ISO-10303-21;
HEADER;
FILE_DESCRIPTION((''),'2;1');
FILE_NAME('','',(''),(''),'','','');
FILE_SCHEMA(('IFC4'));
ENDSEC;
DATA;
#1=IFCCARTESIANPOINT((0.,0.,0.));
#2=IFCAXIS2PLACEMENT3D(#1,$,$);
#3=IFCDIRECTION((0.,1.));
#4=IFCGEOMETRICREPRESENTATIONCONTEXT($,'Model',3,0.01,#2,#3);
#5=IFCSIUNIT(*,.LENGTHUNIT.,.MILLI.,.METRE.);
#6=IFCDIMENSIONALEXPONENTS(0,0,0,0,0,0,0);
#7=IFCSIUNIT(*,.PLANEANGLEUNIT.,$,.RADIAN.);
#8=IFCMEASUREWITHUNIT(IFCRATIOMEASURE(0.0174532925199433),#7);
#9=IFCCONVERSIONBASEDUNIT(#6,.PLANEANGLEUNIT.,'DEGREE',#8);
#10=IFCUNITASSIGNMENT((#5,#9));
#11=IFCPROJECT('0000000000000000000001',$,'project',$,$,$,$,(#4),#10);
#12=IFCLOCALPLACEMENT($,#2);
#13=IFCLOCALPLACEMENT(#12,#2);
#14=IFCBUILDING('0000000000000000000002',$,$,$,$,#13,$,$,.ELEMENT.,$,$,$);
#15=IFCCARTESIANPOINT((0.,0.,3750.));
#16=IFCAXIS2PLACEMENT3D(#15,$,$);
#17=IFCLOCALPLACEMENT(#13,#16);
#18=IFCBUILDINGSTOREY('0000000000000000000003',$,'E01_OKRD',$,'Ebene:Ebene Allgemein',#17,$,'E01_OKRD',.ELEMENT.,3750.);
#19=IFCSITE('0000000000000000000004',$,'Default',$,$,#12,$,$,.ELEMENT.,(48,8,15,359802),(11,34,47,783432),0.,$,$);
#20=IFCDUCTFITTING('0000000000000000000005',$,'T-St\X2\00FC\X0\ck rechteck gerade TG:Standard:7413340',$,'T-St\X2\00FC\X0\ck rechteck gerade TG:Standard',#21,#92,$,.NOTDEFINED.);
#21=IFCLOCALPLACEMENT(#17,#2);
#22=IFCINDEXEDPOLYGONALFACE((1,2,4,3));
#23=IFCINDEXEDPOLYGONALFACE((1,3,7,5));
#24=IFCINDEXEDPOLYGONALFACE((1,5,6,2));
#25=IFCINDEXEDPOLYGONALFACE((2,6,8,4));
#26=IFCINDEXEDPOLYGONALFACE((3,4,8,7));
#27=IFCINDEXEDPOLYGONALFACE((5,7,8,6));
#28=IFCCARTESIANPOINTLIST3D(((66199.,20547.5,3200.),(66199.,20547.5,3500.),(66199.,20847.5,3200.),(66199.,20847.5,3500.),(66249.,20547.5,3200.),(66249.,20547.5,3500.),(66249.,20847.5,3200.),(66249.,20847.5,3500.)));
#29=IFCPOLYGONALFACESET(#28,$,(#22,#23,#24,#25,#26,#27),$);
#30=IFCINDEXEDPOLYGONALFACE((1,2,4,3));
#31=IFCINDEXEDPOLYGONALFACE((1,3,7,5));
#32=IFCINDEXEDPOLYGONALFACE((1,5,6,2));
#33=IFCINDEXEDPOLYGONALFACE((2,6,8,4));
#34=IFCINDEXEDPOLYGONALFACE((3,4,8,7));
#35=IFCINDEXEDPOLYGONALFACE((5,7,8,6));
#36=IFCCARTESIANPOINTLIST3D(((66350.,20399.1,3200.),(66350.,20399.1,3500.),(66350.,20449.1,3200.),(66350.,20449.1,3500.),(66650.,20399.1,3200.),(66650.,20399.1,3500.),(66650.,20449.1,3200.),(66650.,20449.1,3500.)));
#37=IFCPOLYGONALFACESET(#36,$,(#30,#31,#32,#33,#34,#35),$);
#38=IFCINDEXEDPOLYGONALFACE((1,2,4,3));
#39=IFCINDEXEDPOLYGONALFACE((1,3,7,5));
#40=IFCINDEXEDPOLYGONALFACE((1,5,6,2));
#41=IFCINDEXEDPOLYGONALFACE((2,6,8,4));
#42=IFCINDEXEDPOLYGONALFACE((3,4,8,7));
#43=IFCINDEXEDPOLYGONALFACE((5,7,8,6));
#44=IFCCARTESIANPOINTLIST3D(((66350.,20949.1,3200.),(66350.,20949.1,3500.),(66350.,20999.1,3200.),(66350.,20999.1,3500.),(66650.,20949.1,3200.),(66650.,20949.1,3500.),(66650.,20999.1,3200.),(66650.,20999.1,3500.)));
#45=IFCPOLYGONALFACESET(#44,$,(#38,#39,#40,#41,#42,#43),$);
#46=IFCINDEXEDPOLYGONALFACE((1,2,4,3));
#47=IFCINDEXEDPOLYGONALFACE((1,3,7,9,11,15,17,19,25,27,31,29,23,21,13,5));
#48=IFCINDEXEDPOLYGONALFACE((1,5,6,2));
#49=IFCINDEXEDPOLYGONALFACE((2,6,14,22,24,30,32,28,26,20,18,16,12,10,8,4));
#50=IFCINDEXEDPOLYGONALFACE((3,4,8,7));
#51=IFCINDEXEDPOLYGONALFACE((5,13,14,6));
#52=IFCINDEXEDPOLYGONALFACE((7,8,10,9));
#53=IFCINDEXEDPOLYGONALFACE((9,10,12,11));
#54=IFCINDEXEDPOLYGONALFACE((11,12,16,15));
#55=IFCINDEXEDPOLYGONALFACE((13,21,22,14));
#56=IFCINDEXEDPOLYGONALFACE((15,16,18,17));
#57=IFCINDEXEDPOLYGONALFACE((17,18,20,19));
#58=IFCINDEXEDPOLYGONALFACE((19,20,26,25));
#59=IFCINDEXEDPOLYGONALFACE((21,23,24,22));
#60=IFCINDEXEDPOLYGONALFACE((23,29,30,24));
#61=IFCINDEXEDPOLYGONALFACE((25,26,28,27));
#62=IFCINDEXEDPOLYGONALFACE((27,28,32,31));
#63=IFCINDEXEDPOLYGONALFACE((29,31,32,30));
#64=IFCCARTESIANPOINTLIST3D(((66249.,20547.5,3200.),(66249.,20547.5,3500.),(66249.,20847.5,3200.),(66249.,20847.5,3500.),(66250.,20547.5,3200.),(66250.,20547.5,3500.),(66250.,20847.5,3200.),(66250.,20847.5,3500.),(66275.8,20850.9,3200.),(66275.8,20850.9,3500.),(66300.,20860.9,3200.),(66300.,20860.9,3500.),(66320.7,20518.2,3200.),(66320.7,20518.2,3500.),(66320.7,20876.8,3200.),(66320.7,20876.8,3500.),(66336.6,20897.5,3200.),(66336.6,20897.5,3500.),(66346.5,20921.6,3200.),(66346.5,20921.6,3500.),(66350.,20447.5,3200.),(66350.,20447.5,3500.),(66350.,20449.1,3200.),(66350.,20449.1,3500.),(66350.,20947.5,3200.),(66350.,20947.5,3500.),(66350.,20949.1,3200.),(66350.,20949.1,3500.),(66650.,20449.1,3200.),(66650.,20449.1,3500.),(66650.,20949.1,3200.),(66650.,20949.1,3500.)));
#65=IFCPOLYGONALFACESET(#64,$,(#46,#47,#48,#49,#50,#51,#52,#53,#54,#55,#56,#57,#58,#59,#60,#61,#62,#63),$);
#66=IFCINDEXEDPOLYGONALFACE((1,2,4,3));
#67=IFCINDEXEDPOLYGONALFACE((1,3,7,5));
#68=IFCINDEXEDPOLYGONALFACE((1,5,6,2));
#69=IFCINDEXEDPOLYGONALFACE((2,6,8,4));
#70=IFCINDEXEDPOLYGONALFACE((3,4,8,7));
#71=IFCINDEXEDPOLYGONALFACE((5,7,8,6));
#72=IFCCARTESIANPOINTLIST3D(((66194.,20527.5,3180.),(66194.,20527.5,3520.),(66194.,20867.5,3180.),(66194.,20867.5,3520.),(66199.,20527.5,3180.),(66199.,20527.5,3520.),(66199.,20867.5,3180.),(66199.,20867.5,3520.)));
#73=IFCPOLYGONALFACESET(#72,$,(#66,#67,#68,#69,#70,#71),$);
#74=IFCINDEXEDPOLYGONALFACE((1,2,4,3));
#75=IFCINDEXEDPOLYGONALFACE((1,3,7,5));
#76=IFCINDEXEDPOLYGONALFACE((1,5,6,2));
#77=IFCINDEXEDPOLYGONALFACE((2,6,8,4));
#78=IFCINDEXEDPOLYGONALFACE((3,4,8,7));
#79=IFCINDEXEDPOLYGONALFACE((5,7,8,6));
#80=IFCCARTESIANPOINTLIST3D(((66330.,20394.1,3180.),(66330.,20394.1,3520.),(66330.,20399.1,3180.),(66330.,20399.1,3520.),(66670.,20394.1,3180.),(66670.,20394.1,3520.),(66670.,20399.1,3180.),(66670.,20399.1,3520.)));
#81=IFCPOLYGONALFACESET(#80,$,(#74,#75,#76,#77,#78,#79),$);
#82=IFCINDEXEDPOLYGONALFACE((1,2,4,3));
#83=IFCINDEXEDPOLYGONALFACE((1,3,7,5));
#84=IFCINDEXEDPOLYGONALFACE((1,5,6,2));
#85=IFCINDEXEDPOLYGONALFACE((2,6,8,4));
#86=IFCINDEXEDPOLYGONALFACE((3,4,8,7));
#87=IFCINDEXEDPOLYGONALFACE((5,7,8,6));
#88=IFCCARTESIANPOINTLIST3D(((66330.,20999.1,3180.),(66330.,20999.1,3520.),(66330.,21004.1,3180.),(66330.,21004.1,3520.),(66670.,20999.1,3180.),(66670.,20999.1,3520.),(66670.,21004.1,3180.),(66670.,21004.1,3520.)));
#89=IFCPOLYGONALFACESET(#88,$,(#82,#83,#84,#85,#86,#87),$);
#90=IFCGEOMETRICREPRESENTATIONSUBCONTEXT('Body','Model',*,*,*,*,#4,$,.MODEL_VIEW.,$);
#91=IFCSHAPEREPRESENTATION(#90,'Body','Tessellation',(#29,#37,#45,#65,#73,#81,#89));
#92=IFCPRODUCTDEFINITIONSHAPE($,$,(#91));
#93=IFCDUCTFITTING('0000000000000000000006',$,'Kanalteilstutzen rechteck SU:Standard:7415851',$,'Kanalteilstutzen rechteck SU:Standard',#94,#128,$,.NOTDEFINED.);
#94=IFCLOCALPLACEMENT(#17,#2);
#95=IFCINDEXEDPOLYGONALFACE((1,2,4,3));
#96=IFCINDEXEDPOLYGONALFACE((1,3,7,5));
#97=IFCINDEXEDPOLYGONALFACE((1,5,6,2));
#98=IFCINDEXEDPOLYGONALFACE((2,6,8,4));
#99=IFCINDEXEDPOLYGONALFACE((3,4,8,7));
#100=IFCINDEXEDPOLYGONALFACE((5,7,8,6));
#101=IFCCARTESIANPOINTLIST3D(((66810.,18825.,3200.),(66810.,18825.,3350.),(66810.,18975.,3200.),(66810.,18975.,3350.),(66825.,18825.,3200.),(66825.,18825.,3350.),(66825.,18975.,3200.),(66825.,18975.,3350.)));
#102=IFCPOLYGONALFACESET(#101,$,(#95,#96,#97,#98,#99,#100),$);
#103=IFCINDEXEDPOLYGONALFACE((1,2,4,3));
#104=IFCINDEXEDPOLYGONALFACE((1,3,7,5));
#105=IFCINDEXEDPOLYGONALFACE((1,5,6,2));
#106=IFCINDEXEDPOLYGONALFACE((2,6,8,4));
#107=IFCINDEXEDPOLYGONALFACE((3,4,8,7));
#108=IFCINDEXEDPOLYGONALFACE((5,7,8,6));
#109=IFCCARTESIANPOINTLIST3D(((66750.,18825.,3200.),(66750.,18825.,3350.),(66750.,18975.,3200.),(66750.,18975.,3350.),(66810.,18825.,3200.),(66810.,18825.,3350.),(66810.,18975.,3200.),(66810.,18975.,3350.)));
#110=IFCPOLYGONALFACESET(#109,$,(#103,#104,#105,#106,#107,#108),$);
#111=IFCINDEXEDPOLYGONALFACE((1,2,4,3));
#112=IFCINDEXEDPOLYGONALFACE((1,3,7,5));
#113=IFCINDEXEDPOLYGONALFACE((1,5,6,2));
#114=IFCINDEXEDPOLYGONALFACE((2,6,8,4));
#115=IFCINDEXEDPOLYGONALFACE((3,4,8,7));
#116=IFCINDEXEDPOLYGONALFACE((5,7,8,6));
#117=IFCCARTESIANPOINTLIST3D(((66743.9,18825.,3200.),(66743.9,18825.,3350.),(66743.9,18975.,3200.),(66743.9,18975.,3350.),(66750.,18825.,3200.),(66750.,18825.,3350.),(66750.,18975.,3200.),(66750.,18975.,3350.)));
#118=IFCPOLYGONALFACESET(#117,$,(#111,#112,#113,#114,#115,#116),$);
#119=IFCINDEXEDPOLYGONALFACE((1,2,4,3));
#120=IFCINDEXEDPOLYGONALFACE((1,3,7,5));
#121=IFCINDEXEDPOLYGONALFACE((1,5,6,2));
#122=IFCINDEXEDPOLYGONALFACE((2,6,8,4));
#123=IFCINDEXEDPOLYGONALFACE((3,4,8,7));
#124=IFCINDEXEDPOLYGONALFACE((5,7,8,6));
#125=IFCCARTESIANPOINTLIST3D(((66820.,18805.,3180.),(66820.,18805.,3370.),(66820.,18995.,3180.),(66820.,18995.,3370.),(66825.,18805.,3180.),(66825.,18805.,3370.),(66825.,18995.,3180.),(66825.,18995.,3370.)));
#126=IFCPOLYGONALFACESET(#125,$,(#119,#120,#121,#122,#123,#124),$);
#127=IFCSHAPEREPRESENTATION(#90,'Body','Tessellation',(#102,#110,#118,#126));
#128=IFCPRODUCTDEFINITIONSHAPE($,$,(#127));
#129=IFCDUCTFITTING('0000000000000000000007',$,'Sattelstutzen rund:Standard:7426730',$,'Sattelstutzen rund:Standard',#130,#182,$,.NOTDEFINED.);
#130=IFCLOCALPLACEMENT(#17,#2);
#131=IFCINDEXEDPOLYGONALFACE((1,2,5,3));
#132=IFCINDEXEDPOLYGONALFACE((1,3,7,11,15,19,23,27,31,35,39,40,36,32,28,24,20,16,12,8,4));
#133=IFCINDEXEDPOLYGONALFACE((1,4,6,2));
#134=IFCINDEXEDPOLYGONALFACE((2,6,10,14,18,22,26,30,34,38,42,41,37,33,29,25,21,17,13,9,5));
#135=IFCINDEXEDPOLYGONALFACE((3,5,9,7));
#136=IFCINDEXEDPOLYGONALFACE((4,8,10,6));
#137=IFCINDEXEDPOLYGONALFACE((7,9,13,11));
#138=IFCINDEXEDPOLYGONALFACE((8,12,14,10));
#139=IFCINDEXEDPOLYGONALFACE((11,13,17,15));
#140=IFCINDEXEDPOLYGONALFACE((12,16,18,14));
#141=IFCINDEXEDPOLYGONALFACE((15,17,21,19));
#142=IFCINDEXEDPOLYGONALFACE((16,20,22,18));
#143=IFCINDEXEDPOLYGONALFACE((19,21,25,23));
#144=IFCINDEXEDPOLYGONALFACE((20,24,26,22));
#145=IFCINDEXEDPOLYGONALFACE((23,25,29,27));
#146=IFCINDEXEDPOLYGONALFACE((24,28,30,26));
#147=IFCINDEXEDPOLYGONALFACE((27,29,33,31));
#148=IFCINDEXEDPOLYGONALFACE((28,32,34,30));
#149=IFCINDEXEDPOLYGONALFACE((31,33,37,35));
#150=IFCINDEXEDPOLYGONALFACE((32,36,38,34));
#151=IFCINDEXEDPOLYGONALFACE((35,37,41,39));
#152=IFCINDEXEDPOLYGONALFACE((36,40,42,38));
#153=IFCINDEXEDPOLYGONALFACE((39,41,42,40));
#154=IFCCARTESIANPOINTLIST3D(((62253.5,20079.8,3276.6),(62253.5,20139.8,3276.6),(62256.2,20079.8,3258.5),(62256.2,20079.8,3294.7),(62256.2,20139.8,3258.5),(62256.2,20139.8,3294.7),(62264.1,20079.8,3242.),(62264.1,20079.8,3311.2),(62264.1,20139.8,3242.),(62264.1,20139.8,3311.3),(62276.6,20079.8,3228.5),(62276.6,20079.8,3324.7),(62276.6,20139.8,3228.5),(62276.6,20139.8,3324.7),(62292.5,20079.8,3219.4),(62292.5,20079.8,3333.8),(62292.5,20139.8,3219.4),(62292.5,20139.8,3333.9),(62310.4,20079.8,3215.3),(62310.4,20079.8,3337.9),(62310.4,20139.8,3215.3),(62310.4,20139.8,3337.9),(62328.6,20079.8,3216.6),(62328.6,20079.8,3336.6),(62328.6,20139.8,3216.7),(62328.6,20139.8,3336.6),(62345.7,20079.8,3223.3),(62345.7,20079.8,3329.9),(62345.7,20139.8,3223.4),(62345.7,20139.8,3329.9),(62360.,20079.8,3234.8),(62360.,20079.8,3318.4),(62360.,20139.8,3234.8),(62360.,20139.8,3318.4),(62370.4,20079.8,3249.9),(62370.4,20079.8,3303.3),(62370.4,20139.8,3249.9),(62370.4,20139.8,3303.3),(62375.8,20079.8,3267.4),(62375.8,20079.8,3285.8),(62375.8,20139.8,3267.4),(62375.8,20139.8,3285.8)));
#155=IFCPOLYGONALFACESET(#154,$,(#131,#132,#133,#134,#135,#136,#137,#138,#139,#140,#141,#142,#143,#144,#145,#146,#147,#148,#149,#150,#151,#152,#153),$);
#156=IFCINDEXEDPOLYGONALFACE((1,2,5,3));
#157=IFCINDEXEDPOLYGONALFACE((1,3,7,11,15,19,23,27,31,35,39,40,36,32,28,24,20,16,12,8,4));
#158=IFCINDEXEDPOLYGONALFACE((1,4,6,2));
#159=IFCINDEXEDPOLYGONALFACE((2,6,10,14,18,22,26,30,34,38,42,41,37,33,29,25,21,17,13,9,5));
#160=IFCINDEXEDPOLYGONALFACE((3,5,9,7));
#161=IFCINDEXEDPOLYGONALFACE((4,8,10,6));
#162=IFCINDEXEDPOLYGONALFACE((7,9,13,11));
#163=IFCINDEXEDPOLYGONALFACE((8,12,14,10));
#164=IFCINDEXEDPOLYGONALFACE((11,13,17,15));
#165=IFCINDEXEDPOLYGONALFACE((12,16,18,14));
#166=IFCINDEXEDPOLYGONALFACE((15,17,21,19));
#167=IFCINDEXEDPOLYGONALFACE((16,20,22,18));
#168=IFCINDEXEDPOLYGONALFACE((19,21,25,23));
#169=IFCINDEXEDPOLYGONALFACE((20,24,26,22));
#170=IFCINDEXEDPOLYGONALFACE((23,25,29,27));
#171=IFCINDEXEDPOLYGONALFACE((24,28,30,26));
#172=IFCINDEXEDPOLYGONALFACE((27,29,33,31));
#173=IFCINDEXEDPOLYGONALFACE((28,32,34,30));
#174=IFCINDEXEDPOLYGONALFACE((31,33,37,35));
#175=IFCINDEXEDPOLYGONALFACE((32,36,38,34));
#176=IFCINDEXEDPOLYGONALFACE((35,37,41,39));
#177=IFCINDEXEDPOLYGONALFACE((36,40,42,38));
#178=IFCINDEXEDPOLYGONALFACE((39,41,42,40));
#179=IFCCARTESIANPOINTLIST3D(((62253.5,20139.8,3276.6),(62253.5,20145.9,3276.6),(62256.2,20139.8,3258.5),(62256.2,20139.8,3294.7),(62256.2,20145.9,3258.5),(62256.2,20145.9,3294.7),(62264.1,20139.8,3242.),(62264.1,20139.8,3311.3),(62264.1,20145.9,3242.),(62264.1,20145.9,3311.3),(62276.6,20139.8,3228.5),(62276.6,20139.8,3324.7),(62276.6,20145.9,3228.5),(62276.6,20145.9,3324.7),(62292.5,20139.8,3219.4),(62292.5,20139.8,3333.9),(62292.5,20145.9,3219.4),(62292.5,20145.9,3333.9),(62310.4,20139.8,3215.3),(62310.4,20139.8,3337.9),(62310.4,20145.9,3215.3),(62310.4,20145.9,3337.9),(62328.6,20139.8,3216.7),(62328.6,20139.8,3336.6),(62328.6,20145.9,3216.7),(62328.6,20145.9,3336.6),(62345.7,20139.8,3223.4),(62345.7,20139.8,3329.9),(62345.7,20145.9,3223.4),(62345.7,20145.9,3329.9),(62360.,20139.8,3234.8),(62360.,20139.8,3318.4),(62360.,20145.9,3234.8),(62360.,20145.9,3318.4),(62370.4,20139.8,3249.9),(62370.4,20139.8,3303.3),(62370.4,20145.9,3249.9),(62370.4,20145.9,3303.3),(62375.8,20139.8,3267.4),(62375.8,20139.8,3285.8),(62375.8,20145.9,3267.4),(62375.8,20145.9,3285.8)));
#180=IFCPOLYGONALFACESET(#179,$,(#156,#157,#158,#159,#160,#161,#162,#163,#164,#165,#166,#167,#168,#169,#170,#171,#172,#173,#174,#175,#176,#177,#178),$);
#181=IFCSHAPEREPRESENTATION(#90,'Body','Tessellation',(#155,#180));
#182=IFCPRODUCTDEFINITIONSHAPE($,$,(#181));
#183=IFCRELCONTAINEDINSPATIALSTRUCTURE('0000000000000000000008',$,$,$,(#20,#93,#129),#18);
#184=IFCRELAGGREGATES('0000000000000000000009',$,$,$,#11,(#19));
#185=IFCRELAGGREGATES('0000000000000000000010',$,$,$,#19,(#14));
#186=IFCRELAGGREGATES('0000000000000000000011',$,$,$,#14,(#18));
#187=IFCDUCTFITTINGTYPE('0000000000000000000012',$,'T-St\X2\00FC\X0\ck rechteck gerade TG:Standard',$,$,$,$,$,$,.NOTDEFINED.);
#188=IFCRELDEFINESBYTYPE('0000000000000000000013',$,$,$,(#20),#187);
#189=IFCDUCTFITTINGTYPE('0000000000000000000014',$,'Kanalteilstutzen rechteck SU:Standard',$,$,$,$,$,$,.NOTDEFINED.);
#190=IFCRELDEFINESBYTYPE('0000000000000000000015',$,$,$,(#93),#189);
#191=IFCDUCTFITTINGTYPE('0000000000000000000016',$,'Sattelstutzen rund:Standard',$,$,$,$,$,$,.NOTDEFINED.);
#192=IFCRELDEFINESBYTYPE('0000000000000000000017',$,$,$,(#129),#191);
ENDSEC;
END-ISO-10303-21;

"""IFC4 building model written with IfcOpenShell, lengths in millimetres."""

from ifc_helpers import new_model, entity, si_unit, converted_unit, direction, frame, frame_2d, origin, origin_2d_with_axis, place, context, subcontext, project, spatial, polyline, circle_curve, parameter, trimmed, segment, composite_curve, rectangle, circle, outline, extrude, source, transform, mapped, type_object, type_shapes, element, save


model = new_model("IFC4")

# Units and contexts
model_context = context("Model", 3, precision=0.01, world=origin(), true_north=direction((0.0, 1.0)))
body_context = subcontext(model_context, "Body", "Model", "MODEL_VIEW")
ifc_project = project(units=[si_unit("LENGTHUNIT", "METRE", prefix="MILLI"), converted_unit("PLANEANGLEUNIT", "DEGREE", entity("IfcRatioMeasure", 0.0174532925199433), si_unit("PLANEANGLEUNIT", "RADIAN"), dimensions=[0, 0, 0, 0, 0, 0, 0])], contexts=[model_context])

# Site, building, storey
site_placement = place(None, origin())
site = spatial("IfcSite", under=ifc_project, at=site_placement, Name="Default", CompositionType="ELEMENT", RefLatitude=(48, 8, 15, 359802), RefLongitude=(11, 34, 47, 783432), RefElevation=0.0)
building_placement = place(site_placement, origin())
building = spatial("IfcBuilding", under=site, at=building_placement, CompositionType="ELEMENT")
storey_placement = place(building_placement, frame((0.0, 0.0, 3750.0)))
storey = spatial("IfcBuildingStorey", under=building, at=storey_placement, Name="E01_OKRD", ObjectType="Ebene:Ebene Allgemein", LongName="E01_OKRD", CompositionType="ELEMENT", Elevation=3750.0)

# Duct fittings
duct_fitting_type_1 = type_object("IfcDuctFittingType", Name="T-Stück rechteck gerade TG:Standard", PredefinedType="NOTDEFINED")
shared_shape_1 = source(origin(), body_context, "Body", "SweptSolid", [
    extrude(rectangle(XDim=50.0, YDim=300.0, at=frame_2d((0.0, 0.0), x_axis=(1.0, 0.0))), frame((0.0, -276.0, -150.0), z_axis=(0.0, 0.0, 1.0), x_axis=(0.0, -1.0, 0.0)), (0.0, 0.0, 1.0), 300.0),
    extrude(rectangle(XDim=50.0, YDim=300.0, at=frame_2d((0.0, 0.0), x_axis=(1.0, 0.0))), frame((273.4, 0.0, -150.0), z_axis=(0.0, 0.0, 1.0), x_axis=(-1.0, 0.0, 0.0)), (0.0, 0.0, 1.0), 300.0),
    extrude(rectangle(XDim=50.0, YDim=300.0, at=origin_2d_with_axis()), frame((-276.6, 0.0, -150.0)), (0.0, 0.0, 1.0), 300.0),
    extrude(outline(composite_curve([segment(trimmed(circle_curve(frame_2d((-250.6, -119.8), x_axis=(-1.0, 0.0)), 100.0), [parameter(180.0)], [parameter(270.0)], True, "PARAMETER"), False, "CONTINUOUS"), segment(polyline([(-150.6, -119.8), (-150.6, -120.8)]), True, "CONTINUOUS"), segment(polyline([(-150.6, -120.8), (149.4, -120.8)]), True, "CONTINUOUS"), segment(polyline([(149.4, -120.8), (149.4, -119.8)]), True, "CONTINUOUS"), segment(trimmed(circle_curve(frame_2d((249.4, -119.8), x_axis=(-1.0, 0.0)), 100.0), [parameter(270.0)], [parameter(0.0)], True, "PARAMETER"), False, "CONTINUOUS"), segment(polyline([(249.4, -19.8), (251.0, -19.8)]), True, "CONTINUOUS"), segment(polyline([(251.0, -19.8), (251.0, 280.2)]), True, "CONTINUOUS"), segment(polyline([(251.0, 280.2), (-249.0, 280.2)]), True, "CONTINUOUS"), segment(polyline([(-249.0, 280.2), (-249.0, -19.8)]), True, "CONTINUOUS"), segment(polyline([(-249.0, -19.8), (-250.6, -19.8)]), True, "CONTINUOUS")], self_intersect=False)), frame((-0.6, -130.2, -150.0), z_axis=(0.0, 0.0, -1.0), x_axis=(-1.0, 0.0, 0.0)), (0.0, 0.0, -1.0), 300.0),
    extrude(rectangle(XDim=5.0, YDim=340.0, at=frame_2d((0.0, 0.0), x_axis=(1.0, 0.0))), frame((0.0, -303.5, -170.0), z_axis=(0.0, 0.0, 1.0), x_axis=(0.0, 1.0, 0.0)), (0.0, 0.0, 1.0), 340.0),
    extrude(rectangle(XDim=5.0, YDim=340.0, at=frame_2d((0.0, 0.0), x_axis=(1.0, 0.0))), frame((300.9, 0.0, -170.0), z_axis=(0.0, 0.0, 1.0), x_axis=(-1.0, 0.0, 0.0)), (0.0, 0.0, 1.0), 340.0),
    extrude(rectangle(XDim=5.0, YDim=340.0, at=origin_2d_with_axis()), frame((-304.1, 0.0, -170.0), z_axis=(0.0, 0.0, 1.0), x_axis=(-1.0, 0.0, 0.0)), (0.0, 0.0, 1.0), 340.0),
])
type_shapes(duct_fitting_type_1, [shared_shape_1])
duct_fitting_1_placement = place(storey_placement, frame((66500.0, 20697.5, 3350.0), z_axis=(0.0, 0.0, 1.0), x_axis=(0.0, -1.0, 0.0)))
element("IfcDuctFitting", 1, at=duct_fitting_1_placement, inside=storey, type_object=duct_fitting_type_1, Name="T-Stück rechteck gerade TG:Standard:7413340", ObjectType="T-Stück rechteck gerade TG:Standard", PredefinedType="NOTDEFINED", context=body_context, shape_type="MappedRepresentation", body=[
    mapped(shared_shape_1, transform((0.0, 0.0, 0.0), scale=1.0)),
])
duct_fitting_type_2 = type_object("IfcDuctFittingType", Name="Kanalteilstutzen rechteck SU:Standard", PredefinedType="NOTDEFINED")
shared_shape_2 = source(origin(), body_context, "Body", "SweptSolid", [
    extrude(rectangle(XDim=150.0, YDim=15.0, at=origin_2d_with_axis()), frame((67.5, 0.0, -75.0), z_axis=(0.0, 0.0, 1.0), x_axis=(0.0, -1.0, 0.0)), (0.0, 0.0, 1.0), 150.0),
    extrude(rectangle(XDim=150.0, YDim=60.0, at=frame_2d((0.0, 0.0), x_axis=(1.0, 0.0))), frame((30.0, 0.0, -75.0), z_axis=(0.0, 0.0, 1.0), x_axis=(0.0, -1.0, 0.0)), (0.0, 0.0, 1.0), 150.0),
    extrude(rectangle(XDim=150.0, YDim=6.1, at=frame_2d((0.0, 0.0), x_axis=(1.0, 0.0))), frame((-3.0, 0.0, -75.0), z_axis=(0.0, 0.0, 1.0), x_axis=(0.0, -1.0, 0.0)), (0.0, 0.0, 1.0), 150.0),
    extrude(rectangle(XDim=190.0, YDim=5.0, at=origin_2d_with_axis()), frame((72.5, 0.0, -95.0), z_axis=(0.0, 0.0, 1.0), x_axis=(0.0, -1.0, 0.0)), (0.0, 0.0, 1.0), 190.0),
])
type_shapes(duct_fitting_type_2, [shared_shape_2])
duct_fitting_2_placement = place(storey_placement, frame((66750.0, 18900.0, 3275.0), z_axis=(0.000013, 0.0, -1.0), x_axis=(1.0, 0.0, 0.000013)))
element("IfcDuctFitting", 2, at=duct_fitting_2_placement, inside=storey, type_object=duct_fitting_type_2, Name="Kanalteilstutzen rechteck SU:Standard:7415851", ObjectType="Kanalteilstutzen rechteck SU:Standard", PredefinedType="NOTDEFINED", context=body_context, shape_type="MappedRepresentation", body=[
    mapped(shared_shape_2, transform((0.0, 0.0, 0.0), scale=1.0)),
])
duct_fitting_type_3 = type_object("IfcDuctFittingType", Name="Sattelstutzen rund:Standard", PredefinedType="NOTDEFINED")
shared_shape_3 = source(origin(), body_context, "Body", "SweptSolid", [
    extrude(circle(Radius=61.5, at=frame_2d((0.0, 0.0), x_axis=(1.0, 0.0))), frame((0.0, 0.0, 0.0), z_axis=(1.0, 0.0, 0.0), x_axis=(0.0, 1.0, 0.0)), (0.0, 0.0, 1.0), 60.0),
    extrude(circle(Radius=61.5, at=frame_2d((0.0, 0.0), x_axis=(1.0, 0.0))), frame((-6.1, 0.0, 0.0), z_axis=(1.0, 0.0, 0.0), x_axis=(0.0, 1.0, 0.0)), (0.0, 0.0, 1.0), 6.1),
])
type_shapes(duct_fitting_type_3, [shared_shape_3])
duct_fitting_3_placement = place(storey_placement, frame((62315.0, 20139.8, 3276.6), z_axis=(0.0, 0.000188, -1.0), x_axis=(0.0, -1.0, -0.000188)))
element("IfcDuctFitting", 3, at=duct_fitting_3_placement, inside=storey, type_object=duct_fitting_type_3, Name="Sattelstutzen rund:Standard:7426730", ObjectType="Sattelstutzen rund:Standard", PredefinedType="NOTDEFINED", context=body_context, shape_type="MappedRepresentation", body=[
    mapped(shared_shape_3, transform((0.0, 0.0, 0.0), scale=1.0)),
])

save(model, "model.ifc")
